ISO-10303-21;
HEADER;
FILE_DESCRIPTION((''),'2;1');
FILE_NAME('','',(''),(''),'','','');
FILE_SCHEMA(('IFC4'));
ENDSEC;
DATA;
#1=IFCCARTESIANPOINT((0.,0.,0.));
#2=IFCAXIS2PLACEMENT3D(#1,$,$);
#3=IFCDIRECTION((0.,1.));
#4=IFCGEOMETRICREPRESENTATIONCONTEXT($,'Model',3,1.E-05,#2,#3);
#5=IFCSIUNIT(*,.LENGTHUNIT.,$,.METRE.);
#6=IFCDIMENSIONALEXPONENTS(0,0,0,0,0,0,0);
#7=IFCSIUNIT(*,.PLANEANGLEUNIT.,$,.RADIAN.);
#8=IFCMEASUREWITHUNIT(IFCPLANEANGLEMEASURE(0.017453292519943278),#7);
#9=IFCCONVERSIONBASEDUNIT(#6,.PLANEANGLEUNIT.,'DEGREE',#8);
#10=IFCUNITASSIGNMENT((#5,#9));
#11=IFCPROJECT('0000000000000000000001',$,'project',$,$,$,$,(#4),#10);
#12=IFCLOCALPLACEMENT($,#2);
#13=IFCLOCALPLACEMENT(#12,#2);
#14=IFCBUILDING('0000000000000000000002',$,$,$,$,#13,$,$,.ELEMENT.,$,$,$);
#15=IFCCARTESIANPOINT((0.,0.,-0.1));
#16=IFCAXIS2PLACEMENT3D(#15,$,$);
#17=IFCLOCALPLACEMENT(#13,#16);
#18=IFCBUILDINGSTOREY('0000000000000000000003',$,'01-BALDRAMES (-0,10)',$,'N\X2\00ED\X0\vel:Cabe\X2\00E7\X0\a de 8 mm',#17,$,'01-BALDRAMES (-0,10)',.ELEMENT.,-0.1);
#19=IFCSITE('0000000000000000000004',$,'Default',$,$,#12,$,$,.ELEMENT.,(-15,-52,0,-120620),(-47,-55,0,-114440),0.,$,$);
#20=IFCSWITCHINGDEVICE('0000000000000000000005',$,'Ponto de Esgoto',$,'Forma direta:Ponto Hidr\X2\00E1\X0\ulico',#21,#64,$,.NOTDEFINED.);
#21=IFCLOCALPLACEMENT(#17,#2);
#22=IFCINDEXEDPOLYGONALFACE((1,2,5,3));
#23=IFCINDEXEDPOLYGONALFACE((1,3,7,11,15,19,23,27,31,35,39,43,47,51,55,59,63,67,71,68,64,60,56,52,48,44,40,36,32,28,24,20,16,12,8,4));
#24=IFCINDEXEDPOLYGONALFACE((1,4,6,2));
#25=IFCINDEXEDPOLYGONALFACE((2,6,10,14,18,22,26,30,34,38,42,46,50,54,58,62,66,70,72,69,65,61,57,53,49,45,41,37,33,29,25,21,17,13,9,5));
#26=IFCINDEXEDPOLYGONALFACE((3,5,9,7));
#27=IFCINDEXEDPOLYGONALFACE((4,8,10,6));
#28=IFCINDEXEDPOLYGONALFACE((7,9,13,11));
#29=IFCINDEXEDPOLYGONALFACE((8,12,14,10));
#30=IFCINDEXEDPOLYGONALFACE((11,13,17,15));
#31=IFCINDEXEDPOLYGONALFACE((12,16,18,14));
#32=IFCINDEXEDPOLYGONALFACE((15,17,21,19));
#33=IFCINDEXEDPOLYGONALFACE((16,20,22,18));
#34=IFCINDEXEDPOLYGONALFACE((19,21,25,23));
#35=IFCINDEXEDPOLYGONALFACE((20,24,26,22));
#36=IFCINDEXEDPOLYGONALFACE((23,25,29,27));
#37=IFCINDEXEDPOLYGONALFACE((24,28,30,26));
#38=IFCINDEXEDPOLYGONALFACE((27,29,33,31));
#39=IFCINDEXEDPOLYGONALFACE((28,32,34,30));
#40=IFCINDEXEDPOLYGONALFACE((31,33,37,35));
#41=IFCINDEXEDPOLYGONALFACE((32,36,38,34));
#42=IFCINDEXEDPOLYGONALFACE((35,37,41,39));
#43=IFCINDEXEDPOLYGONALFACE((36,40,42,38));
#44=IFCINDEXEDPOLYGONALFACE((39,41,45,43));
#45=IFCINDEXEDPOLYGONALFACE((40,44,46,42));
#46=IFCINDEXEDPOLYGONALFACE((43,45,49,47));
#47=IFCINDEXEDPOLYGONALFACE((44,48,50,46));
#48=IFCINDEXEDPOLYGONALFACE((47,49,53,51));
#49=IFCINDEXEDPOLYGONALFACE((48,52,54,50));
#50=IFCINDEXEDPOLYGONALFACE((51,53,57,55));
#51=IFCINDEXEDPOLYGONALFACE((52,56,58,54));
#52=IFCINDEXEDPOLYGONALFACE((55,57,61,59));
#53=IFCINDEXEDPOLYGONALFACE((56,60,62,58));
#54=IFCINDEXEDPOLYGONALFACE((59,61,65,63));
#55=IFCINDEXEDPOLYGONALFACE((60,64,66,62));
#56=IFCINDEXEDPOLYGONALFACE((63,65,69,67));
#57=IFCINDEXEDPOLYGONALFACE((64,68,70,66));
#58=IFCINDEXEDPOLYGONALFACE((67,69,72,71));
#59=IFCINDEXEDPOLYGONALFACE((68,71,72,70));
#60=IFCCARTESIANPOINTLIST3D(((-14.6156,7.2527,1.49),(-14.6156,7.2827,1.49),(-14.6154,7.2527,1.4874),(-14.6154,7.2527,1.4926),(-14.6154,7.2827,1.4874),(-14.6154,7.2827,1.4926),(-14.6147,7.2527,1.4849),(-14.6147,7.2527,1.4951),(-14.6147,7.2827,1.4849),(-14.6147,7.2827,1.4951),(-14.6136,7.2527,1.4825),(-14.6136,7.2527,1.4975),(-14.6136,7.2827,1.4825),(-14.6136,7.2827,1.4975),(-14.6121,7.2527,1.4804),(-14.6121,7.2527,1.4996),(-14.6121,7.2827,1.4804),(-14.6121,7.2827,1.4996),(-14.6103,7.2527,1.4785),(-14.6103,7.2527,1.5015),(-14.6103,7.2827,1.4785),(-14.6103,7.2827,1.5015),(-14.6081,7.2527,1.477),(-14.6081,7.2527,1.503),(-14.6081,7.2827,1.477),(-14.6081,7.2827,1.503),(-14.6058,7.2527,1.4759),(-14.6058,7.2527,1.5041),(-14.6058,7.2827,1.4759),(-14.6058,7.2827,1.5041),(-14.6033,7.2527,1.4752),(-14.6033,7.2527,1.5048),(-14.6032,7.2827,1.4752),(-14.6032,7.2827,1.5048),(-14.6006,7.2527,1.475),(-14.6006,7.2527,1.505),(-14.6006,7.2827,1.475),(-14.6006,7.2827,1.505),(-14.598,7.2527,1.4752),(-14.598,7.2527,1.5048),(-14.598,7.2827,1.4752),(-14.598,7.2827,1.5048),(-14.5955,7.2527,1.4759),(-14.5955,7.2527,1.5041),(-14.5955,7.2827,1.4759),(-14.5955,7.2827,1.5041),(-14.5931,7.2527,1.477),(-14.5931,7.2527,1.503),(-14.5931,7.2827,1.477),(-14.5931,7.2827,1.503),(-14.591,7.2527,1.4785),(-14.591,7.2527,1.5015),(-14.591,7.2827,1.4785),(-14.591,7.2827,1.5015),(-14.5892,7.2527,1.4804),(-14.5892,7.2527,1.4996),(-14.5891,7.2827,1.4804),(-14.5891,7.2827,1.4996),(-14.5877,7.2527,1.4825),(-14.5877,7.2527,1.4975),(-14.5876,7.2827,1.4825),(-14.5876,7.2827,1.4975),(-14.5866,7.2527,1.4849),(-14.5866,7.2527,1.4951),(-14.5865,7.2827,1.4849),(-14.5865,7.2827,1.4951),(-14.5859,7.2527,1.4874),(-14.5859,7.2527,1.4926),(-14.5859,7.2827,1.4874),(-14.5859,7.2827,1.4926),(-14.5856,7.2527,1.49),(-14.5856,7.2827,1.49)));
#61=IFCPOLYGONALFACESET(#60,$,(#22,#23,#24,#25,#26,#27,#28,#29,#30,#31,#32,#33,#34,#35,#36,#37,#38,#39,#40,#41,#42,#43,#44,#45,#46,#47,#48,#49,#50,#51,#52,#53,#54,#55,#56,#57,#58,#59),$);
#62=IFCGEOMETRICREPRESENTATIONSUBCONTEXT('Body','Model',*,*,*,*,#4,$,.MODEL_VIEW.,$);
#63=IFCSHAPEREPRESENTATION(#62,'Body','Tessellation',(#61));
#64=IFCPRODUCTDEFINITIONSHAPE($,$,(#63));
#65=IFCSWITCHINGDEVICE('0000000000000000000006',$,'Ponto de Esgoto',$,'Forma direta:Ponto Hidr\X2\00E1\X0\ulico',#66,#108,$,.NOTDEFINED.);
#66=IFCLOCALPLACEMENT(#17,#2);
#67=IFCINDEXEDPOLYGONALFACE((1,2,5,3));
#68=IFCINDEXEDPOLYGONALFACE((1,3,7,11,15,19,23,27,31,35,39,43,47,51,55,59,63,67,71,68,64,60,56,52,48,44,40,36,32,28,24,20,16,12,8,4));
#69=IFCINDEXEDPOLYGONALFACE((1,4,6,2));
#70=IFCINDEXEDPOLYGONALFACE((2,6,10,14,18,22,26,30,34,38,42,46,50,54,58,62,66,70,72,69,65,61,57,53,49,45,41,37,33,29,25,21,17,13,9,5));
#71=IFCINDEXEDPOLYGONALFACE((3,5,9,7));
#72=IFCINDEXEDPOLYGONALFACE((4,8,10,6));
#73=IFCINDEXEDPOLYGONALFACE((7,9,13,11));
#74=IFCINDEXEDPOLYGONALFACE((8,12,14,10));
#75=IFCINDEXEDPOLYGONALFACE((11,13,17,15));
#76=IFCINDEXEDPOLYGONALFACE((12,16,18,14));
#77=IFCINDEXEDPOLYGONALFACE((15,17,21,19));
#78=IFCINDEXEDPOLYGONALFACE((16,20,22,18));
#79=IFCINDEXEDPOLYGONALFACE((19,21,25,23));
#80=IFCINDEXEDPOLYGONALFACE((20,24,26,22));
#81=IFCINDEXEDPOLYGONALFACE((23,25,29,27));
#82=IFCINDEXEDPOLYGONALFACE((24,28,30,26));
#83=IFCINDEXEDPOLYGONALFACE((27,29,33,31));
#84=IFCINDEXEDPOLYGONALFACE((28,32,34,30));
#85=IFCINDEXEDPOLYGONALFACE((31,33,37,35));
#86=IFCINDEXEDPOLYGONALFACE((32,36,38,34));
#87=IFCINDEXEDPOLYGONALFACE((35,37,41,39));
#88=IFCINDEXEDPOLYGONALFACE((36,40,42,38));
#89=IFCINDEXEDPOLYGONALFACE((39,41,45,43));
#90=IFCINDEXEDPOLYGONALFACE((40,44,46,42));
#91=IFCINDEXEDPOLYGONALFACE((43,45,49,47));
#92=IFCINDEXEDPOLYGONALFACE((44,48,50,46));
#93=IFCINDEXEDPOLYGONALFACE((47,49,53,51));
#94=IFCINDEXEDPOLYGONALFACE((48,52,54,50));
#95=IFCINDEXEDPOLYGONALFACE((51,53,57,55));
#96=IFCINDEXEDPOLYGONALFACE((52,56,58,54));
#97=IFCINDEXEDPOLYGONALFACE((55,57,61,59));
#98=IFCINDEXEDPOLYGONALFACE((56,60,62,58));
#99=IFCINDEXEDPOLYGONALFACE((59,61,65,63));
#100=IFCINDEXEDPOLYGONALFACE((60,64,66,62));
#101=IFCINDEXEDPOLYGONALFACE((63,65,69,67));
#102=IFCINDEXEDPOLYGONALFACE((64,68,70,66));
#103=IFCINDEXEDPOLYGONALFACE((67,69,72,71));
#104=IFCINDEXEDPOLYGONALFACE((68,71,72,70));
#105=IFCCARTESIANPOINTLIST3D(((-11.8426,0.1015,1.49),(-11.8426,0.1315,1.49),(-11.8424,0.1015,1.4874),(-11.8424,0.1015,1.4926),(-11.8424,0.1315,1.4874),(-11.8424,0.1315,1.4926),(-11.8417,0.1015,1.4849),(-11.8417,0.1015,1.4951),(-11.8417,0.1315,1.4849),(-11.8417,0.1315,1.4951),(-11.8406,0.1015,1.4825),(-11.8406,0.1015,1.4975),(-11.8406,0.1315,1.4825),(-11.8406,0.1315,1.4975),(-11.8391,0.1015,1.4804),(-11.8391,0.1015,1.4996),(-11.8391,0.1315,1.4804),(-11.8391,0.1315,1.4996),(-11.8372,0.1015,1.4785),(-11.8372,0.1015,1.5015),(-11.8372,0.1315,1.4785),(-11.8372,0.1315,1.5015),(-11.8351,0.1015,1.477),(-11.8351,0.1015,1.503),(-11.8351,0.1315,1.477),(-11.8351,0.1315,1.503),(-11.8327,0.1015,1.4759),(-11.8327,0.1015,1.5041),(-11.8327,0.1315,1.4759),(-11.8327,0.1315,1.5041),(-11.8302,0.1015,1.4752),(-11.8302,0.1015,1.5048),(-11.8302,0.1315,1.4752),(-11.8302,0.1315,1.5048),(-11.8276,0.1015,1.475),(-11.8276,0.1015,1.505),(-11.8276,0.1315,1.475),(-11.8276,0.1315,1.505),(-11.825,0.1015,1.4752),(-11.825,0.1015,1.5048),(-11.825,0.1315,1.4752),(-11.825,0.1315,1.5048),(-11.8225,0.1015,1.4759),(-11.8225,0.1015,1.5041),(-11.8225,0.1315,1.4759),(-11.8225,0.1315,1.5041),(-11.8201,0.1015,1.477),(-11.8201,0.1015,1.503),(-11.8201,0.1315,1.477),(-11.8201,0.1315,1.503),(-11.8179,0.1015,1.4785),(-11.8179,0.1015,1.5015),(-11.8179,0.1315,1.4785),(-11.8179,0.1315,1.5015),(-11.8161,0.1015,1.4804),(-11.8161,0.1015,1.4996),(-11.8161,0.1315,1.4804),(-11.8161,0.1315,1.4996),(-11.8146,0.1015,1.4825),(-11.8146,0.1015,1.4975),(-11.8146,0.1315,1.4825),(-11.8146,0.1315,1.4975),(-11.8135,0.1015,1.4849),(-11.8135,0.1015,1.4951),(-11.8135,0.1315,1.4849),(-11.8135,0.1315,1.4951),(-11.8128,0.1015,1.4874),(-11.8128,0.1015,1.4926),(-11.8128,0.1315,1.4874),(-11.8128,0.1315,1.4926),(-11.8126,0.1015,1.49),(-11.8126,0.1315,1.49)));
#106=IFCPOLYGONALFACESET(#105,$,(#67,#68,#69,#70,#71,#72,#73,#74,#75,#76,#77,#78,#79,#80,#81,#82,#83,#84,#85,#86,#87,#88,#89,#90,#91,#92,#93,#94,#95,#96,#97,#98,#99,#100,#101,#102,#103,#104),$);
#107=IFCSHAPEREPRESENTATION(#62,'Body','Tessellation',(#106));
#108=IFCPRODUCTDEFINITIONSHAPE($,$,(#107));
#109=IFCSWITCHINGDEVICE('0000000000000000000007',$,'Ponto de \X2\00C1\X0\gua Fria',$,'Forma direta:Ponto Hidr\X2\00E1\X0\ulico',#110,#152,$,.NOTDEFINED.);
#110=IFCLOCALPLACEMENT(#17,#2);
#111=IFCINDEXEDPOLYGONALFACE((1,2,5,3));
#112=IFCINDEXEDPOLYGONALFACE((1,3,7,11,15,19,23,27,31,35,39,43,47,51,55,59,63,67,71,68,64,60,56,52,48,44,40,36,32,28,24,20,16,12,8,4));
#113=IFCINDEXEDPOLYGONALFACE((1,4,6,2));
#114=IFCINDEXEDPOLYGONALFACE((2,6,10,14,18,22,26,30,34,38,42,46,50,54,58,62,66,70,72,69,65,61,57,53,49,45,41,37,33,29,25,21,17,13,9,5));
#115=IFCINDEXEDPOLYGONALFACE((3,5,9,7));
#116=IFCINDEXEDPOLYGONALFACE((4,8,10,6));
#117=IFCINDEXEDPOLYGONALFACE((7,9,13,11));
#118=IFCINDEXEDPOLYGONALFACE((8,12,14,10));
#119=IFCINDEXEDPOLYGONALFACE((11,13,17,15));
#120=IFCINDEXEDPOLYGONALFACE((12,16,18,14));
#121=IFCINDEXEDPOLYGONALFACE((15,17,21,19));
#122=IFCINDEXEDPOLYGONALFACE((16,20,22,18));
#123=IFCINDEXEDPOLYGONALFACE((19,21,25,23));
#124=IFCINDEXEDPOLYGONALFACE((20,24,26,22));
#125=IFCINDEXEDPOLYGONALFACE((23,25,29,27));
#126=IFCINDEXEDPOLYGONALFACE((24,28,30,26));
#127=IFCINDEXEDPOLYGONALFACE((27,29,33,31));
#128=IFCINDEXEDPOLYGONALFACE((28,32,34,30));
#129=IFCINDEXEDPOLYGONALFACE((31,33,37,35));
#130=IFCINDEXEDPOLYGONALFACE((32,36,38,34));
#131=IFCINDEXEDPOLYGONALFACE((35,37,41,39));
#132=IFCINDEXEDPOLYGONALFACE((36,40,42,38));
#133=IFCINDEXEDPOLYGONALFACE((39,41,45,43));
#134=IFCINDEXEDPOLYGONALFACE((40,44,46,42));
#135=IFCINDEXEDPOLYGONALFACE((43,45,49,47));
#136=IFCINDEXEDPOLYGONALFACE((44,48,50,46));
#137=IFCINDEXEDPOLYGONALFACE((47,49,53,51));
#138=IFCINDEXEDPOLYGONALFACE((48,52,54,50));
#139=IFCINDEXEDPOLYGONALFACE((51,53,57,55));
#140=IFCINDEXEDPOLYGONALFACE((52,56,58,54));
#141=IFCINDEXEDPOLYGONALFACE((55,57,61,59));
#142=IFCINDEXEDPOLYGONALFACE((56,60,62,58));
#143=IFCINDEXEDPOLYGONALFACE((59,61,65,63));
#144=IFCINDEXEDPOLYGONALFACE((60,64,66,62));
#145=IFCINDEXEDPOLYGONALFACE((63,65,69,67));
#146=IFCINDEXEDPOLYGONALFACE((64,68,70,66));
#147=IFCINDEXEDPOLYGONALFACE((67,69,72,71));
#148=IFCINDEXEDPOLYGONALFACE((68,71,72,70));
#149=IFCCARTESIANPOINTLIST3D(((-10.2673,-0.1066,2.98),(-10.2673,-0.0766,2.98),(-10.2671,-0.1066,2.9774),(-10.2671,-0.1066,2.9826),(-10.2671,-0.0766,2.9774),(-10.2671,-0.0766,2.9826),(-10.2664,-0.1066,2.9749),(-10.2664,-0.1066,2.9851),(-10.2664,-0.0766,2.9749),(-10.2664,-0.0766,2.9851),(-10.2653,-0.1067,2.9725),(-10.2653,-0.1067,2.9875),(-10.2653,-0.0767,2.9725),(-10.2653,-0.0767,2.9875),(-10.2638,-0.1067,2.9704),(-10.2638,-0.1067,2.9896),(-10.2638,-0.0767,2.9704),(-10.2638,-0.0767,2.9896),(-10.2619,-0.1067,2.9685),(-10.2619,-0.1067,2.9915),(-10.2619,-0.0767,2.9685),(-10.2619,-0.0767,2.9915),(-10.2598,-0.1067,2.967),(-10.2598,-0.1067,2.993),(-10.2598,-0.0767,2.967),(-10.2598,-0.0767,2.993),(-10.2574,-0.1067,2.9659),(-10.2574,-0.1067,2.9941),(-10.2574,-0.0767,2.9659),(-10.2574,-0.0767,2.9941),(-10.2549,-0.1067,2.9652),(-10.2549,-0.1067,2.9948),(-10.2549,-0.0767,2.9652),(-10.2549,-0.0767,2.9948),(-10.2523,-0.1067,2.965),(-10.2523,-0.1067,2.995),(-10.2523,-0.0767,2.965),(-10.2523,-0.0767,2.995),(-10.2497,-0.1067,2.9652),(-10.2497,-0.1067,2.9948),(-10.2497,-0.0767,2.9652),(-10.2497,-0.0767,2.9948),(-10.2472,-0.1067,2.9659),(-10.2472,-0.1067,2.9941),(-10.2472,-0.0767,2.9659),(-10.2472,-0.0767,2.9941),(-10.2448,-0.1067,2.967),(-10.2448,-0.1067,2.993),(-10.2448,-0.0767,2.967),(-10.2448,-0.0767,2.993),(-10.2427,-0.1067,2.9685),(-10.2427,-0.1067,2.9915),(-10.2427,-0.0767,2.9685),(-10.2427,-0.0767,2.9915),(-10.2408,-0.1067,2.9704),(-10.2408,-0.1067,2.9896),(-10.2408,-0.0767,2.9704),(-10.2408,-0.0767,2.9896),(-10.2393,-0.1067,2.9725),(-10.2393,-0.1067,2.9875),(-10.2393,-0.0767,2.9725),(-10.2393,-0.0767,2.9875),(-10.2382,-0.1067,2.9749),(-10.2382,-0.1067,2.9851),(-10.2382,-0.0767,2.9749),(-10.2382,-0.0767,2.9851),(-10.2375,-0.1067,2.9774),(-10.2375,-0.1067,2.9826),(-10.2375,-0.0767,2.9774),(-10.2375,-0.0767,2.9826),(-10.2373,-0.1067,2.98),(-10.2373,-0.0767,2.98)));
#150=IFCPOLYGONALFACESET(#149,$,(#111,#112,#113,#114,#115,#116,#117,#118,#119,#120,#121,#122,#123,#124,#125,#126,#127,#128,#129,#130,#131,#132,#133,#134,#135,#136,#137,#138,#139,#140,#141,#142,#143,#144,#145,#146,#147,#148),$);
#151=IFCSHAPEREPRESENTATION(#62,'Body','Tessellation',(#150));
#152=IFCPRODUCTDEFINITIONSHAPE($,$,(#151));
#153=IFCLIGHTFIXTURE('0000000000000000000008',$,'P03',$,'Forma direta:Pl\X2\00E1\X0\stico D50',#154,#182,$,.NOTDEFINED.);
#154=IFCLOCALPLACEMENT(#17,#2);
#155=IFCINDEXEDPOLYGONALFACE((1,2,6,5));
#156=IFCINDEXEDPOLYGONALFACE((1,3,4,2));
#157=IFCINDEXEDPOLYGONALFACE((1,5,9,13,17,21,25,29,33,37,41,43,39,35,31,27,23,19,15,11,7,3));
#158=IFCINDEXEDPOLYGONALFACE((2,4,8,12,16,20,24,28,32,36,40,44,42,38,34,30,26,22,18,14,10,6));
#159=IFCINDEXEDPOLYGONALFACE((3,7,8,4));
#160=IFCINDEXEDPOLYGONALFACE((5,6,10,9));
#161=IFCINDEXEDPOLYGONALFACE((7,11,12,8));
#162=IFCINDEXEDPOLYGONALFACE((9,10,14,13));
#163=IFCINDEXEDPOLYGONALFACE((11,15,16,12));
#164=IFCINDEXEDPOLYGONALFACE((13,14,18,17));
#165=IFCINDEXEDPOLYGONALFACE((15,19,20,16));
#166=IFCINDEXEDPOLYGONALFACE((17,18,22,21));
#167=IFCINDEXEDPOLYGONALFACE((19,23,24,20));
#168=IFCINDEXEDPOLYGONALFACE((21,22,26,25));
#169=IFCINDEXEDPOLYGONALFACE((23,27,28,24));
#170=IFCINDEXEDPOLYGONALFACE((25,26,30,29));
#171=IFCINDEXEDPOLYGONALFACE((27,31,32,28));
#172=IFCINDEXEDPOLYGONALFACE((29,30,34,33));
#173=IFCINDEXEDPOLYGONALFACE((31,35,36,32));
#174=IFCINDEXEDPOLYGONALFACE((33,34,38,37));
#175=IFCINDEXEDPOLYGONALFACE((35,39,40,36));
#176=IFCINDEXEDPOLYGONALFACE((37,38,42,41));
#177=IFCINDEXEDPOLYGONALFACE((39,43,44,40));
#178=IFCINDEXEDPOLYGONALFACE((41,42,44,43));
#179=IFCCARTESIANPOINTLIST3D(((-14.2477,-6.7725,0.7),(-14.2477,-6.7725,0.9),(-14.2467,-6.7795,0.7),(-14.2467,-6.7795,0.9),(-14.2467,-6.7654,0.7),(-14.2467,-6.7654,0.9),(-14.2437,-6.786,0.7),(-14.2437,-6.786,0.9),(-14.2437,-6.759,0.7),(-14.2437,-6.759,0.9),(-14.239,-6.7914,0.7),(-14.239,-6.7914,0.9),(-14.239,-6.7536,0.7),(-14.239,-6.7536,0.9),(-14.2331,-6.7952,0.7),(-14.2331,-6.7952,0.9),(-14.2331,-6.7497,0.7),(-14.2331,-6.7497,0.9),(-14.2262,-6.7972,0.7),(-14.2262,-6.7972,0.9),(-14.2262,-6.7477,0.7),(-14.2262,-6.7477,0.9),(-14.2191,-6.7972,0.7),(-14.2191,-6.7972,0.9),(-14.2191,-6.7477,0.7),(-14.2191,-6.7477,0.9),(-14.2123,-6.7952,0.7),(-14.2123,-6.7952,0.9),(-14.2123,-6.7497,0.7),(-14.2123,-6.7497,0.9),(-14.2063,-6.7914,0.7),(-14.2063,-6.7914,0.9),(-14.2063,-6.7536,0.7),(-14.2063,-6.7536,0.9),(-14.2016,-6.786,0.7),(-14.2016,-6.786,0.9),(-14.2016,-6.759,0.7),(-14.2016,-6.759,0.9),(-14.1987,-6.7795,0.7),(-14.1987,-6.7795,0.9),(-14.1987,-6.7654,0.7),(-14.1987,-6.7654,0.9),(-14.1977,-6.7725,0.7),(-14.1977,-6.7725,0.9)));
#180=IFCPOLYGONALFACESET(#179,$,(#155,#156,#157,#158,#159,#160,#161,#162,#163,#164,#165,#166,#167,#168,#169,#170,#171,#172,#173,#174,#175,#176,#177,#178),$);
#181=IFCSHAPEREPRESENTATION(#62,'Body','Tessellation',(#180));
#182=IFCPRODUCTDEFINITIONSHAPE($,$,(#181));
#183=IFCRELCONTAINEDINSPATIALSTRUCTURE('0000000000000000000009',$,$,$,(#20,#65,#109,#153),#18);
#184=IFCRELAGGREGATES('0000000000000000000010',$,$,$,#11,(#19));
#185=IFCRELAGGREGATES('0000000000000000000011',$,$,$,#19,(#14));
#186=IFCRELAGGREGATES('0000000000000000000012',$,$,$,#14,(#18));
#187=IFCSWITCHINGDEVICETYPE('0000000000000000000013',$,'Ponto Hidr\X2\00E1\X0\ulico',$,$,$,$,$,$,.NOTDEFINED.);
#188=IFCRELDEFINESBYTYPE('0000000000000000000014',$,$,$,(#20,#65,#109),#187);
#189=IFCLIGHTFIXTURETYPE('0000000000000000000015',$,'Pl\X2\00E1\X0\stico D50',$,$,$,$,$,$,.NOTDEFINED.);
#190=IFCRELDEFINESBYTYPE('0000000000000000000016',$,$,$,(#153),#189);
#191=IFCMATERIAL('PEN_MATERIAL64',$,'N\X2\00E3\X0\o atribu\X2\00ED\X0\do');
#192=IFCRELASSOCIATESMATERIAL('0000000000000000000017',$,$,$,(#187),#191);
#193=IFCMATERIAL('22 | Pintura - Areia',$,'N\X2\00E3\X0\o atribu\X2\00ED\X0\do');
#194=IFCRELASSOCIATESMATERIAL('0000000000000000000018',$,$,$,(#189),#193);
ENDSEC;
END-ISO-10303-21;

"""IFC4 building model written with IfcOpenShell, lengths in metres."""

from ifc_helpers import new_model, entity, si_unit, converted_unit, direction, frame, origin, place, context, subcontext, project, spatial, arc, indexed_curve, outline, extrude, material, type_object, element, save


model = new_model("IFC4")

# Units and contexts
model_context = context("Model", 3, precision=1e-05, world=origin(), true_north=direction((0.0, 1.0)))
body_context = subcontext(model_context, "Body", "Model", "MODEL_VIEW")
ifc_project = project(units=[si_unit("LENGTHUNIT", "METRE"), converted_unit("PLANEANGLEUNIT", "DEGREE", entity("IfcPlaneAngleMeasure", 0.017453292519943278), si_unit("PLANEANGLEUNIT", "RADIAN"), dimensions=[0, 0, 0, 0, 0, 0, 0])], contexts=[model_context])

# Site, building, storey
site_placement = place(None, origin())
site = spatial("IfcSite", under=ifc_project, at=site_placement, Name="Default", CompositionType="ELEMENT", RefLatitude=(-15, -52, 0, -120620), RefLongitude=(-47, -55, 0, -114440), RefElevation=0.0)
building_placement = place(site_placement, origin())
building = spatial("IfcBuilding", under=site, at=building_placement, CompositionType="ELEMENT")
storey_placement = place(building_placement, frame((0.0, 0.0, -0.1)))
storey = spatial("IfcBuildingStorey", under=building, at=storey_placement, Name="01-BALDRAMES (-0,10)", ObjectType="Nível:Cabeça de 8 mm", LongName="01-BALDRAMES (-0,10)", CompositionType="ELEMENT", Elevation=-0.1)

# Switching devices
ifc_material_1 = material(Name="PEN_MATERIAL64", Category="Não atribuído")
switching_device_type = type_object("IfcSwitchingDeviceType", Name="Ponto Hidráulico", PredefinedType="NOTDEFINED", material=ifc_material_1)
switching_device_1_placement = place(storey_placement, origin())
element("IfcSwitchingDevice", 1, at=switching_device_1_placement, inside=storey, type_object=switching_device_type, Name="Ponto de Esgoto", ObjectType="Forma direta:Ponto Hidráulico", PredefinedType="NOTDEFINED", context=body_context, shape_type="SweptSolid", body=[
    extrude(outline(indexed_curve([(-0.0013, -0.0149), (0.0013, -0.0149), (0.0039, -0.0145), (0.0063, -0.0136), (0.0086, -0.0123), (0.0106, -0.0106), (0.0123, -0.0086), (0.0136, -0.0063), (0.0145, -0.0039), (0.0149, -0.0013), (0.0149, 0.0013), (0.0145, 0.0039), (0.0136, 0.0063), (0.0123, 0.0086), (0.0106, 0.0106), (0.0086, 0.0123), (0.0063, 0.0136), (0.0039, 0.0145), (0.0013, 0.0149), (-0.0013, 0.0149), (-0.0039, 0.0145), (-0.0063, 0.0136), (-0.0086, 0.0123), (-0.0106, 0.0106), (-0.0123, 0.0086), (-0.0136, 0.0063), (-0.0145, 0.0039), (-0.0149, 0.0013), (-0.0149, -0.0013), (-0.0145, -0.0039), (-0.0136, -0.0063), (-0.0123, -0.0086), (-0.0106, -0.0106), (-0.0086, -0.0123), (-0.0063, -0.0136), (-0.0039, -0.0145), (-0.0013, -0.0149)], self_intersect=False)), frame((-14.6006, 7.2527, 1.49), z_axis=(0.000299, 1.0, 0.0), x_axis=(-0.996195, 0.000298, -0.087156)), (0.0, 0.0, 1.0), 0.03),
])
switching_device_2_placement = place(storey_placement, origin())
element("IfcSwitchingDevice", 2, at=switching_device_2_placement, inside=storey, type_object=switching_device_type, Name="Ponto de Esgoto", ObjectType="Forma direta:Ponto Hidráulico", PredefinedType="NOTDEFINED", context=body_context, shape_type="SweptSolid", body=[
    extrude(outline(indexed_curve([(-0.0013, -0.0149), (0.0013, -0.0149), (0.0039, -0.0145), (0.0063, -0.0136), (0.0086, -0.0123), (0.0106, -0.0106), (0.0123, -0.0086), (0.0136, -0.0063), (0.0145, -0.0039), (0.0149, -0.0013), (0.0149, 0.0013), (0.0145, 0.0039), (0.0136, 0.0063), (0.0123, 0.0086), (0.0106, 0.0106), (0.0086, 0.0123), (0.0063, 0.0136), (0.0039, 0.0145), (0.0013, 0.0149), (-0.0013, 0.0149), (-0.0039, 0.0145), (-0.0063, 0.0136), (-0.0086, 0.0123), (-0.0106, 0.0106), (-0.0123, 0.0086), (-0.0136, 0.0063), (-0.0145, 0.0039), (-0.0149, 0.0013), (-0.0149, -0.0013), (-0.0145, -0.0039), (-0.0136, -0.0063), (-0.0123, -0.0086), (-0.0106, -0.0106), (-0.0086, -0.0123), (-0.0063, -0.0136), (-0.0039, -0.0145), (-0.0013, -0.0149)], self_intersect=False)), frame((-11.8276, 0.1015, 1.49), z_axis=(0.000299, 1.0, 0.0), x_axis=(-0.996195, 0.000298, -0.087156)), (0.0, 0.0, 1.0), 0.03),
])
switching_device_3_placement = place(storey_placement, origin())
element("IfcSwitchingDevice", 3, at=switching_device_3_placement, inside=storey, type_object=switching_device_type, Name="Ponto de Água Fria", ObjectType="Forma direta:Ponto Hidráulico", PredefinedType="NOTDEFINED", context=body_context, shape_type="SweptSolid", body=[
    extrude(outline(indexed_curve([(-0.0013, -0.0149), (0.0013, -0.0149), (0.0039, -0.0145), (0.0063, -0.0136), (0.0086, -0.0123), (0.0106, -0.0106), (0.0123, -0.0086), (0.0136, -0.0063), (0.0145, -0.0039), (0.0149, -0.0013), (0.0149, 0.0013), (0.0145, 0.0039), (0.0136, 0.0063), (0.0123, 0.0086), (0.0106, 0.0106), (0.0086, 0.0123), (0.0063, 0.0136), (0.0039, 0.0145), (0.0013, 0.0149), (-0.0013, 0.0149), (-0.0039, 0.0145), (-0.0063, 0.0136), (-0.0086, 0.0123), (-0.0106, 0.0106), (-0.0123, 0.0086), (-0.0136, 0.0063), (-0.0145, 0.0039), (-0.0149, 0.0013), (-0.0149, -0.0013), (-0.0145, -0.0039), (-0.0136, -0.0063), (-0.0123, -0.0086), (-0.0106, -0.0106), (-0.0086, -0.0123), (-0.0063, -0.0136), (-0.0039, -0.0145), (-0.0013, -0.0149)], self_intersect=False)), frame((-10.2523, -0.1067, 2.98), z_axis=(0.000435, 1.0, 0.0), x_axis=(-0.965926, 0.00042, 0.258819)), (0.0, 0.0, 1.0), 0.03),
])

# Light fixture
ifc_material_2 = material(Name="22 | Pintura - Areia", Category="Não atribuído")
light_fixture_type = type_object("IfcLightFixtureType", Name="Plástico D50", PredefinedType="NOTDEFINED", material=ifc_material_2)
light_fixture_placement = place(storey_placement, origin())
element("IfcLightFixture", 4, at=light_fixture_placement, inside=storey, type_object=light_fixture_type, Name="P03", ObjectType="Forma direta:Plástico D50", PredefinedType="NOTDEFINED", context=body_context, shape_type="SweptSolid", body=[
    extrude(outline(indexed_curve([(0.025, 0.0), (0.0, 0.025), (-0.025, 0.0), (0.0, -0.025)], segments=[arc(1, 2, 3), arc(3, 4, 1)], self_intersect=False)), frame((-14.2227, -6.7725, 0.7)), (0.0, 0.0, 1.0), 0.2),
])

save(model, "model.ifc")
